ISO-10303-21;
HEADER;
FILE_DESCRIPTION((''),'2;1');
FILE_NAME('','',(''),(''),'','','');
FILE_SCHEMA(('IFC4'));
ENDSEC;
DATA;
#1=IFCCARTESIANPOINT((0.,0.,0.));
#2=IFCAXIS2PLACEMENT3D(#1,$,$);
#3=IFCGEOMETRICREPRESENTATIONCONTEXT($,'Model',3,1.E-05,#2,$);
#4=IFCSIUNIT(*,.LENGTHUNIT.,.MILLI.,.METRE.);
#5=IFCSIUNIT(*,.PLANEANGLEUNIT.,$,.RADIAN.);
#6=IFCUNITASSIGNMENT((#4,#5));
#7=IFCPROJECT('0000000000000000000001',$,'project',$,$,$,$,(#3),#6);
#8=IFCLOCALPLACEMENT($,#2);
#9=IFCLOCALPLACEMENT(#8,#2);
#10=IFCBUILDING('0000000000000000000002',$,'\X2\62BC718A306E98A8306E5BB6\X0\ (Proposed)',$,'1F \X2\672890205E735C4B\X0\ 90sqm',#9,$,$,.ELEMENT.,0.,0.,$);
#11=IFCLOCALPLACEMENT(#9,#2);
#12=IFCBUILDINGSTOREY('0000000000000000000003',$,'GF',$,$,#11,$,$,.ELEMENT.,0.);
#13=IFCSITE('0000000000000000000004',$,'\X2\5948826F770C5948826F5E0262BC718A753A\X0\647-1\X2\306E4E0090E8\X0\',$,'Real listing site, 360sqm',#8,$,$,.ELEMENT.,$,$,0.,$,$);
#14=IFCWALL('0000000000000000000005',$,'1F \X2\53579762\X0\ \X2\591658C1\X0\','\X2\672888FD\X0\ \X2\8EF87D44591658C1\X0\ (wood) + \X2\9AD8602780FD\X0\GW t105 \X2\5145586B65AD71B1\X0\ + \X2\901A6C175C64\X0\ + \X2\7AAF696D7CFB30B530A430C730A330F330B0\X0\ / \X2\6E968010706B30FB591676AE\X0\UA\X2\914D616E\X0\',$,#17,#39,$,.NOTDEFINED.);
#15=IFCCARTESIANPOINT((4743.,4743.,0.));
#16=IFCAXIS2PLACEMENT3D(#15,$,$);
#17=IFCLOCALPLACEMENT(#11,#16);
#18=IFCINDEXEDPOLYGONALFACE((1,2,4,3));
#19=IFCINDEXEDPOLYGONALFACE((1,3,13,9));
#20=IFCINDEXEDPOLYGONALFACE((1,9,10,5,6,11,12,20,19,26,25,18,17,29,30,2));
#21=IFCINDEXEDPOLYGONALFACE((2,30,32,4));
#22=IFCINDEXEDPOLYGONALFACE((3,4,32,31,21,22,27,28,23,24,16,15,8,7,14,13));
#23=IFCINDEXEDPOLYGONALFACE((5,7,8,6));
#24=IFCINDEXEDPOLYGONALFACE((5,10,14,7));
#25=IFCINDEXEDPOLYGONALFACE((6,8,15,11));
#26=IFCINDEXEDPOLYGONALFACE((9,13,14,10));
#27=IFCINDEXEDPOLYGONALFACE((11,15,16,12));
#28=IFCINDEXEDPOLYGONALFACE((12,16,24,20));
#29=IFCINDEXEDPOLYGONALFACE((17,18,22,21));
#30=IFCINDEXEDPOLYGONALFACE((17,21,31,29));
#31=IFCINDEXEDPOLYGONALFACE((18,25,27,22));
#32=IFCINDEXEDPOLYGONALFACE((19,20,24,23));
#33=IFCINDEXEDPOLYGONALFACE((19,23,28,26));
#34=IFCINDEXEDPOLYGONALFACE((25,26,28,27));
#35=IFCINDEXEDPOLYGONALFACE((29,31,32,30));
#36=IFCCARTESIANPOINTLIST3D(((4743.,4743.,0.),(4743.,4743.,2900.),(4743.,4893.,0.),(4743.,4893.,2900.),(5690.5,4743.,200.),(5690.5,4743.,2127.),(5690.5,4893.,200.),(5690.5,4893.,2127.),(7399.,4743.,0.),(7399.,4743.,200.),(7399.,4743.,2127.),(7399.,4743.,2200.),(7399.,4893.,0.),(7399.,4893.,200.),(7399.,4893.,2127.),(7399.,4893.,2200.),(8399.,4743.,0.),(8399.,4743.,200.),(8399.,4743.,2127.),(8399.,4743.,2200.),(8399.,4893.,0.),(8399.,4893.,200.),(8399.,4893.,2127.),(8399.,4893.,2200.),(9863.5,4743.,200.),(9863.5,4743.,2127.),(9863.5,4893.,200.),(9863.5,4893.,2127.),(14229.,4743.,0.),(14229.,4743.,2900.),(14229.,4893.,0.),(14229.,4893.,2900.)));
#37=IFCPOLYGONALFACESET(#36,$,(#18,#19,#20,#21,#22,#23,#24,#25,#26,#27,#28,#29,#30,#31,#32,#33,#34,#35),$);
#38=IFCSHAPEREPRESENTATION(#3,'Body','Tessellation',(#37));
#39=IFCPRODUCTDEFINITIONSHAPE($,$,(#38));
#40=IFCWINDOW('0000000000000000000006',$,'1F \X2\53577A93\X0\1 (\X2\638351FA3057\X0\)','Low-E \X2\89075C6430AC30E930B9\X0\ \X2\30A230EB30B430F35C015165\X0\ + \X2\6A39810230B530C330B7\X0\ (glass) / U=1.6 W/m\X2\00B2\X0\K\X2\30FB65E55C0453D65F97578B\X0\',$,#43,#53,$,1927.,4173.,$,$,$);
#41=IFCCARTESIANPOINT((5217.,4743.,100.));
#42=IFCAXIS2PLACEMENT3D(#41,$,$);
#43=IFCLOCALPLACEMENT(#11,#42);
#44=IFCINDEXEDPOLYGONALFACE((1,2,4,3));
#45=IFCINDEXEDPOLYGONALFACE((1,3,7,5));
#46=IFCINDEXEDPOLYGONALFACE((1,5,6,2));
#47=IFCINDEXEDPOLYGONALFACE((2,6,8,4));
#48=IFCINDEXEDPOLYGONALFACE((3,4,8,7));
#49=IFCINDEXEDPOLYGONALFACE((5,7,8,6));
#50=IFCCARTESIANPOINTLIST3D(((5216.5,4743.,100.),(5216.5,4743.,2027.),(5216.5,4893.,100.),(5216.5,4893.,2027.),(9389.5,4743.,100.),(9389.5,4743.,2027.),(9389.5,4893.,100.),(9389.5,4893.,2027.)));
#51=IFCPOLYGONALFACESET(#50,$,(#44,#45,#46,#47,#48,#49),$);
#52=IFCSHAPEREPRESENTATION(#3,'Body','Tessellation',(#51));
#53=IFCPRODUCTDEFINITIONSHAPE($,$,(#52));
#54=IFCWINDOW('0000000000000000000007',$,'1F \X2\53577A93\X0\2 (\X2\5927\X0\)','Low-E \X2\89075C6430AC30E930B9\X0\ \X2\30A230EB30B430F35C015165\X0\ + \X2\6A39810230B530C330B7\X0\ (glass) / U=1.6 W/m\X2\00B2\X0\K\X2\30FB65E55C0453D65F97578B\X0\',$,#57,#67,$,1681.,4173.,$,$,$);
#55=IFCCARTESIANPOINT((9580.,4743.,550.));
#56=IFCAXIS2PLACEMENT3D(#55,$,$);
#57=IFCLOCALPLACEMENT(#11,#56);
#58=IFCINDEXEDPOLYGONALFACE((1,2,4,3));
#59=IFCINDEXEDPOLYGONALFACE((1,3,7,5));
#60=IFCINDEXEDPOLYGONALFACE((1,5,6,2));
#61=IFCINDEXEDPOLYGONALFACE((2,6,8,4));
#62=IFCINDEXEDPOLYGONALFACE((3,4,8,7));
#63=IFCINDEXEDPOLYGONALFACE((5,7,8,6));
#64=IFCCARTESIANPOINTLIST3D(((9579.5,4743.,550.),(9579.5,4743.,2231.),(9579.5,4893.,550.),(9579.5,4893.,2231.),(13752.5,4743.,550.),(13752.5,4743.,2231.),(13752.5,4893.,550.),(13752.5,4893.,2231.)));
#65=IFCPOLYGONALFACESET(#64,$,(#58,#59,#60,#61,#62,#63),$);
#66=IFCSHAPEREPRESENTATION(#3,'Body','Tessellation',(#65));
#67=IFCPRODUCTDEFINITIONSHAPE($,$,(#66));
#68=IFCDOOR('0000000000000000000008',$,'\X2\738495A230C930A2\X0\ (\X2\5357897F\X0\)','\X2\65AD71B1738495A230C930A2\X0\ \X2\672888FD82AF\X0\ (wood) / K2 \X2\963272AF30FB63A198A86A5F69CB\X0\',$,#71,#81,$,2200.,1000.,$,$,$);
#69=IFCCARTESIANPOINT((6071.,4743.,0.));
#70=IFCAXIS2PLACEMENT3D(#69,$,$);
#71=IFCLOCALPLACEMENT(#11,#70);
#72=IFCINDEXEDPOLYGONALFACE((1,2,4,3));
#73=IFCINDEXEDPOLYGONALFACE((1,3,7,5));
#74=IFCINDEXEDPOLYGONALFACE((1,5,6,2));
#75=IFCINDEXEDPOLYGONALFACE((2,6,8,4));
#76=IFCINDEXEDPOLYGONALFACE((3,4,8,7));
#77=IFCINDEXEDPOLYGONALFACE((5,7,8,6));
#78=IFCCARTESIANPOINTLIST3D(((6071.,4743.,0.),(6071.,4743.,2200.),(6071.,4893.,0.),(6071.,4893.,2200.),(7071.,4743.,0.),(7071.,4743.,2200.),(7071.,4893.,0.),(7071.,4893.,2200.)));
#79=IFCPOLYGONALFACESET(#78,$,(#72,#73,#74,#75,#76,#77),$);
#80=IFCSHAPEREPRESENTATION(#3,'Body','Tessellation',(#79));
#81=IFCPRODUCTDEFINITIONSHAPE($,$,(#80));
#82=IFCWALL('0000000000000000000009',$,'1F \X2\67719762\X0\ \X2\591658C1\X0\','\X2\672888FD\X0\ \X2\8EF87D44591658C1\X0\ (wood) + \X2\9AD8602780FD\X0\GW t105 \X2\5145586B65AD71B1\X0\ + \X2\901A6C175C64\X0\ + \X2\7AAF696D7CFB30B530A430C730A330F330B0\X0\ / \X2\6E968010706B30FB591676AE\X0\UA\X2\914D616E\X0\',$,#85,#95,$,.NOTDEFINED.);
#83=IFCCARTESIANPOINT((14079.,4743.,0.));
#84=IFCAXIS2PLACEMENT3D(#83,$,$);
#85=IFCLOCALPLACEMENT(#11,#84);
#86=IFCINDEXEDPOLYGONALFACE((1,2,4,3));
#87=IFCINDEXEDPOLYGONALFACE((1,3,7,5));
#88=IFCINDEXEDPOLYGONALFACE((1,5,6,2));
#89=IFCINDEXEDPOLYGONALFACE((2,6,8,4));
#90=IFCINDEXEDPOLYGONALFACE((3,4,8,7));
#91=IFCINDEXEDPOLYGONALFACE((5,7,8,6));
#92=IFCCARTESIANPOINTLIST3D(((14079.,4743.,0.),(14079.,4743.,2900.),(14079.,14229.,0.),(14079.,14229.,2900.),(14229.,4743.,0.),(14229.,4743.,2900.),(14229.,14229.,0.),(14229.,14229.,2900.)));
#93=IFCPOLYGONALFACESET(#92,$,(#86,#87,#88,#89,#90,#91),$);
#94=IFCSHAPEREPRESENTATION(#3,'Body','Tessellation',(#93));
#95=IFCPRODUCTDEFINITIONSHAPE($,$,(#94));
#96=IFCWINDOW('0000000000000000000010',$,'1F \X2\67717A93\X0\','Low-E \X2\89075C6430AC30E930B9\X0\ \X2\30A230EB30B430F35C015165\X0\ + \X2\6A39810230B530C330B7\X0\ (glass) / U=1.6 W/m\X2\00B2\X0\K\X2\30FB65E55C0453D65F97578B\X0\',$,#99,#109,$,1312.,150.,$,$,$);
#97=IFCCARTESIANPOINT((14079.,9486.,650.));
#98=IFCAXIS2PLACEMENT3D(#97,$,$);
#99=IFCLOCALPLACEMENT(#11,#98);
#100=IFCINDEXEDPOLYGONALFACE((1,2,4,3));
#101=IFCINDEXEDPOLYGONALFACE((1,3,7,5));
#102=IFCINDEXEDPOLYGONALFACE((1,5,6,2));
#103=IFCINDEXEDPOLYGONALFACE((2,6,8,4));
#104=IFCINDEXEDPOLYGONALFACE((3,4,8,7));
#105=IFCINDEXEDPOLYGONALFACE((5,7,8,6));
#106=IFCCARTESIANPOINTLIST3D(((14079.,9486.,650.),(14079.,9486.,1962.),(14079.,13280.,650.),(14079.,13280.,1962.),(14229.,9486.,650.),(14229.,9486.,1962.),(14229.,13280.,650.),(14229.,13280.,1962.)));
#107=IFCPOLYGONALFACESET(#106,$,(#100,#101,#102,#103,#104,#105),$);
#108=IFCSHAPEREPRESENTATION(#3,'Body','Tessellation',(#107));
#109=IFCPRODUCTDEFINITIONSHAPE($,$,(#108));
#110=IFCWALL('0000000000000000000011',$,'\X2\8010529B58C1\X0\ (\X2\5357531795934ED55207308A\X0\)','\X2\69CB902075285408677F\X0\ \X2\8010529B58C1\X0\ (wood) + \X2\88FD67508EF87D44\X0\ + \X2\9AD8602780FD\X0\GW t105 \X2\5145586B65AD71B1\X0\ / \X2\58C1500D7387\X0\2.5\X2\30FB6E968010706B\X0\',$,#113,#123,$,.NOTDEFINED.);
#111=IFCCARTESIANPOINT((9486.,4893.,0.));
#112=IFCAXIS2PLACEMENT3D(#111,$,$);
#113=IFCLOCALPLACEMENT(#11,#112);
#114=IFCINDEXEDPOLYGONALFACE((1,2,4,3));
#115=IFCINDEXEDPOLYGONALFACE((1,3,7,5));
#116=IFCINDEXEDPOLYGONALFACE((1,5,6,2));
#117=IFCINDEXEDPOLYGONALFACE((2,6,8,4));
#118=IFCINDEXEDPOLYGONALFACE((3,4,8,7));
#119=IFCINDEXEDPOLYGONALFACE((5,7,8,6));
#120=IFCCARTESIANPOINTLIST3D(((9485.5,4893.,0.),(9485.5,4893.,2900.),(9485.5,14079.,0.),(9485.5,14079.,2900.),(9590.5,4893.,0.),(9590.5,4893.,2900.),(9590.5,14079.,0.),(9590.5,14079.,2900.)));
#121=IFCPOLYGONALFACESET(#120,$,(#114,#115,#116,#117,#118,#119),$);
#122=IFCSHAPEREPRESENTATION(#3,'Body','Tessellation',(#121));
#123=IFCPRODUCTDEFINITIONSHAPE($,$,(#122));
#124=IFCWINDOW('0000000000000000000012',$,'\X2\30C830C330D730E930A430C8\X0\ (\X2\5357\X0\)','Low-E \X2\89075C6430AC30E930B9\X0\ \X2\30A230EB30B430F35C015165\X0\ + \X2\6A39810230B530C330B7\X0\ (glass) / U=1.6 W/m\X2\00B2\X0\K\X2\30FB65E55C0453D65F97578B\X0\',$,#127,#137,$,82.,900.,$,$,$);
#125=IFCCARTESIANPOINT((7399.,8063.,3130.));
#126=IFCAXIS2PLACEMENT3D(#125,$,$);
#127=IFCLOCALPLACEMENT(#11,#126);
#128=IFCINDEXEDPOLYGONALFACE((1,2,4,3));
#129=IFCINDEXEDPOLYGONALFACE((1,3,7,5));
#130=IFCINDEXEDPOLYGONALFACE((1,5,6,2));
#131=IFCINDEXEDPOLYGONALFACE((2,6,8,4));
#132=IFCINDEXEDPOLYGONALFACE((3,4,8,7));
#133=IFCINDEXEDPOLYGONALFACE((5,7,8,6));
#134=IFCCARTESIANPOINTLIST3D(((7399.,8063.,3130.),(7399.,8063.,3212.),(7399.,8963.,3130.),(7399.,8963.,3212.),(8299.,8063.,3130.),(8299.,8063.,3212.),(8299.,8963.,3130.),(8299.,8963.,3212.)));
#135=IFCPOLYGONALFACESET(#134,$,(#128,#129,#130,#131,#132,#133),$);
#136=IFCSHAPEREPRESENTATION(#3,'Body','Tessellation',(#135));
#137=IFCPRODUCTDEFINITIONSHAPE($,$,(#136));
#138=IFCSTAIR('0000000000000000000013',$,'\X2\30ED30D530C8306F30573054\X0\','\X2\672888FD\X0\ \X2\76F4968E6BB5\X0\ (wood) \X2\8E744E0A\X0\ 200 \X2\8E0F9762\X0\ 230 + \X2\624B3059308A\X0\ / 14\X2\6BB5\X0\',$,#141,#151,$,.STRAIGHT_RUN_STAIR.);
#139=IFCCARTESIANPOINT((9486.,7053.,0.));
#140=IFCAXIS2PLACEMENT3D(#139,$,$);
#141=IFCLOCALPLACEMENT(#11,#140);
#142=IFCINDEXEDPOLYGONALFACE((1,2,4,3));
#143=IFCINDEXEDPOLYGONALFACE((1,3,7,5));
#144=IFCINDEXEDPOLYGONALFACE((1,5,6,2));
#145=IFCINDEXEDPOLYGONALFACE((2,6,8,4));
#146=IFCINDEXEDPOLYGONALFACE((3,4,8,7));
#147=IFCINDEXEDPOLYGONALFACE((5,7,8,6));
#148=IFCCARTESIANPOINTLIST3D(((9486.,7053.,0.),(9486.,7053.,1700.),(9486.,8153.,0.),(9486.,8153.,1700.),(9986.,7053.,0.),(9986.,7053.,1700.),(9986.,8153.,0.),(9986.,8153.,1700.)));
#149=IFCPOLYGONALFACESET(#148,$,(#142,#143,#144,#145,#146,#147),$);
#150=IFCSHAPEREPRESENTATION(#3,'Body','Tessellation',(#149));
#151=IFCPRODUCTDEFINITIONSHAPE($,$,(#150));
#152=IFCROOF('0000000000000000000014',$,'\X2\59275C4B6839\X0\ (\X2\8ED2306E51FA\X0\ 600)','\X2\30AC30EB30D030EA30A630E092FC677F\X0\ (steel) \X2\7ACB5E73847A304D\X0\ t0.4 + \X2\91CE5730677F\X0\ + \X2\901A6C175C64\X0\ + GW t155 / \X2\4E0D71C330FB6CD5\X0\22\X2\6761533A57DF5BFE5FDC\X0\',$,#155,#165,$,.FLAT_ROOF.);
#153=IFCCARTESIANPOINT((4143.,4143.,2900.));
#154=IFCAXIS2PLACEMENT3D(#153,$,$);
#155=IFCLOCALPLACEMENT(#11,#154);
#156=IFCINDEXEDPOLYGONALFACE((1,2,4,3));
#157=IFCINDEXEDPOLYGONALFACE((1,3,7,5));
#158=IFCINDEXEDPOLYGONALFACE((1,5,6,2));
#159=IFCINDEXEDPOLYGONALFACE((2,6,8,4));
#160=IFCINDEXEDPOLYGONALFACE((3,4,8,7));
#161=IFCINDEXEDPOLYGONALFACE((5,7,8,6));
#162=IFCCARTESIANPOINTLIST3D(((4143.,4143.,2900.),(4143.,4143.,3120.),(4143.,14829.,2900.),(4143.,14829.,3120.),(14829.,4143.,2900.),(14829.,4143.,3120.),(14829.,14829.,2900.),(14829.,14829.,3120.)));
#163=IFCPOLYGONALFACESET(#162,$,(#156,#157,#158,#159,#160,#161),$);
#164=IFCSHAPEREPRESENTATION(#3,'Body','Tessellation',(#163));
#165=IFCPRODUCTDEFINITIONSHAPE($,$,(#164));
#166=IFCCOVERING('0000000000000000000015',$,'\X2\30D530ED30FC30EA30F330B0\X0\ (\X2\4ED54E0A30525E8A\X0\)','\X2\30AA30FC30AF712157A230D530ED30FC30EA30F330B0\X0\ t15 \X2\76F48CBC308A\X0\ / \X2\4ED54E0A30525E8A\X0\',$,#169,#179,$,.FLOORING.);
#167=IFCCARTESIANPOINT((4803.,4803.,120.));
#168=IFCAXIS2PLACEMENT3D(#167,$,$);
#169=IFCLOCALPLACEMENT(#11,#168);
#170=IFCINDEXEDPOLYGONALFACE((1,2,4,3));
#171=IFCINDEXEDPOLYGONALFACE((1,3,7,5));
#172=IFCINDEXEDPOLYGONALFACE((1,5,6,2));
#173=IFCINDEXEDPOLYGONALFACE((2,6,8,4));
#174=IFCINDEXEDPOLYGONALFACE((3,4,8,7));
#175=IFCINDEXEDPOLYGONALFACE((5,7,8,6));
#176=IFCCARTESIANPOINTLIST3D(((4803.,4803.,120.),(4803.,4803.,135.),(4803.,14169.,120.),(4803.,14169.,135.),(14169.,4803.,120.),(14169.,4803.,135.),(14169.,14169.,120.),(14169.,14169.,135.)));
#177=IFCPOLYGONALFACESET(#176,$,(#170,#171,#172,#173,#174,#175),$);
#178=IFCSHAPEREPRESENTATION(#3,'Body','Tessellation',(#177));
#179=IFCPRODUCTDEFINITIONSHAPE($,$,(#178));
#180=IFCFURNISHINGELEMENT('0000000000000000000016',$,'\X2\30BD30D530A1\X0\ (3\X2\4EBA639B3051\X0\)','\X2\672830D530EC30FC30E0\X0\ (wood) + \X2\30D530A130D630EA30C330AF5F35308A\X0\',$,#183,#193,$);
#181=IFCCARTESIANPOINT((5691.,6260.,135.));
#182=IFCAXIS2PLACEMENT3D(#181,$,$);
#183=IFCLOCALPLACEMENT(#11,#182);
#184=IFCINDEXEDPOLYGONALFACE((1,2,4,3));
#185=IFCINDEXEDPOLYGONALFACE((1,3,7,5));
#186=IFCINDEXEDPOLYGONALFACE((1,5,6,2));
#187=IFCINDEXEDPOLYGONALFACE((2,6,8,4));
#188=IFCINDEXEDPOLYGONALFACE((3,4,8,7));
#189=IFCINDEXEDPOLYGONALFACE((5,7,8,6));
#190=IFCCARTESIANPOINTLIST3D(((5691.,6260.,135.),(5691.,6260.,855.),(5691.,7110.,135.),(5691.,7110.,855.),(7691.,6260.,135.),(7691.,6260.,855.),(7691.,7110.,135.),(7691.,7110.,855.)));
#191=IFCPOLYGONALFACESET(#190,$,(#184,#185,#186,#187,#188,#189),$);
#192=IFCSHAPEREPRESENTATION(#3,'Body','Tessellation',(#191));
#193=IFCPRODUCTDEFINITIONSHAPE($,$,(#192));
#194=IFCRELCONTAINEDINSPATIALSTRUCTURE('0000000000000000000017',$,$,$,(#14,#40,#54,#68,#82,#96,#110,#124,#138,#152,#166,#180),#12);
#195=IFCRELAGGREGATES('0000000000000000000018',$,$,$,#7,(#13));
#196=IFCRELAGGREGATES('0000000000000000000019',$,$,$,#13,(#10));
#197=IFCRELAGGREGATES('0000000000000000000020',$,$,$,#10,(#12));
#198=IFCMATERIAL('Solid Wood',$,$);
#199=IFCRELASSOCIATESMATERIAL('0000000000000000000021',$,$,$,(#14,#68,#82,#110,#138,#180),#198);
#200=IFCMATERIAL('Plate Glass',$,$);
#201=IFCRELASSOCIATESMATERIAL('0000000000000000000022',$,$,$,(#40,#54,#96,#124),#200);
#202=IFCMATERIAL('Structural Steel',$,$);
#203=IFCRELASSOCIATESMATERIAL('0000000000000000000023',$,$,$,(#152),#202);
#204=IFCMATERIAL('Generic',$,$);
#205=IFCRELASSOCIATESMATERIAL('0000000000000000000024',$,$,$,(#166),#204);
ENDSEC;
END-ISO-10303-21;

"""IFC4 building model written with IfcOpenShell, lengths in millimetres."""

from ifc_helpers import new_model, si_unit, frame, frame_2d, origin, place, context, project, spatial, rectangle, extrude, material, element, fill, save


model = new_model("IFC4")

# Units and contexts
model_context = context("Model", 3, precision=1e-05, world=origin())
ifc_project = project(units=[si_unit("LENGTHUNIT", "METRE", prefix="MILLI"), si_unit("PLANEANGLEUNIT", "RADIAN")], contexts=[model_context])

# Site, building, storey
site_placement = place(None, origin())
site = spatial("IfcSite", under=ifc_project, at=site_placement, Name="奈良県奈良市押熊町647-1の一部", ObjectType="Real listing site, 360sqm", CompositionType="ELEMENT", RefElevation=0.0)
building_placement = place(site_placement, origin())
building = spatial("IfcBuilding", under=site, at=building_placement, Name="押熊の風の家 (Proposed)", ObjectType="1F 木造平屋 90sqm", CompositionType="ELEMENT", ElevationOfRefHeight=0.0, ElevationOfTerrain=0.0)
storey_placement = place(building_placement, origin())
storey = spatial("IfcBuildingStorey", under=building, at=storey_placement, Name="GF", CompositionType="ELEMENT", Elevation=0.0)

# Shared definitions
ifc_material_1 = material(Name="Solid Wood")

# Wall, openings, windows, door
wall_1_placement = place(storey_placement, frame((4743.0, 4743.0, 0.0)))
wall_1 = element("IfcWall", 1, at=wall_1_placement, inside=storey, material=ifc_material_1, Name="1F 南面 外壁", Description="木製 軸組外壁 (wood) + 高性能GW t105 充填断熱 + 通気層 + 窯業系サイディング / 準耐火・外皮UA配慮", PredefinedType="NOTDEFINED", context=model_context, shape_type="SweptSolid", body=[
    extrude(rectangle(XDim=9486.0, YDim=150.0, at=frame_2d((4743.0, 75.0))), frame((4743.0, 4743.0, 0.0)), (0.0, 0.0, 1.0), 2900.0),
])
opening_1_placement = place(storey_placement, frame((5217.0, 4743.0, 100.0)))
opening_1 = element("IfcOpeningElement", 2, at=opening_1_placement, cuts=wall_1, PredefinedType="NOTDEFINED", context=model_context, shape_type="SweptSolid", body=[
    extrude(rectangle(XDim=4173.0, YDim=150.0, at=frame_2d((2086.0, 75.0))), frame((5217.0, 4743.0, 100.0)), (0.0, 0.0, 1.0), 1927.0),
])
opening_2_placement = place(storey_placement, frame((9580.0, 4743.0, 550.0)))
opening_2 = element("IfcOpeningElement", 3, at=opening_2_placement, cuts=wall_1, PredefinedType="NOTDEFINED", context=model_context, shape_type="SweptSolid", body=[
    extrude(rectangle(XDim=4173.0, YDim=150.0, at=frame_2d((2086.0, 75.0))), frame((9580.0, 4743.0, 550.0)), (0.0, 0.0, 1.0), 1681.0),
])
opening_3_placement = place(storey_placement, frame((6071.0, 4743.0, 0.0)))
opening_3 = element("IfcOpeningElement", 4, at=opening_3_placement, cuts=wall_1, PredefinedType="NOTDEFINED", context=model_context, shape_type="SweptSolid", body=[
    extrude(rectangle(XDim=1000.0, YDim=150.0, at=frame_2d((500.0, 75.0))), frame((6071.0, 4743.0, 0.0)), (0.0, 0.0, 1.0), 2200.0),
])
ifc_material_2 = material(Name="Plate Glass")
window_1_placement = place(storey_placement, frame((5217.0, 4743.0, 100.0)))
window_1 = element("IfcWindow", 5, at=window_1_placement, inside=storey, material=ifc_material_2, Name="1F 南窓1 (掃出し)", Description="Low-E 複層ガラス アルゴン封入 + 樹脂サッシ (glass) / U=1.6 W/m²K・日射取得型", OverallHeight=1927.0, OverallWidth=4173.0, context=model_context, shape_type="SweptSolid", body=[
    extrude(rectangle(XDim=4173.0, YDim=150.0, at=frame_2d((2086.0, 75.0))), frame((5217.0, 4743.0, 100.0)), (0.0, 0.0, 1.0), 1927.0),
])
fill(opening_1, window_1)
window_2_placement = place(storey_placement, frame((9580.0, 4743.0, 550.0)))
window_2 = element("IfcWindow", 6, at=window_2_placement, inside=storey, material=ifc_material_2, Name="1F 南窓2 (大)", Description="Low-E 複層ガラス アルゴン封入 + 樹脂サッシ (glass) / U=1.6 W/m²K・日射取得型", OverallHeight=1681.0, OverallWidth=4173.0, context=model_context, shape_type="SweptSolid", body=[
    extrude(rectangle(XDim=4173.0, YDim=150.0, at=frame_2d((2086.0, 75.0))), frame((9580.0, 4743.0, 550.0)), (0.0, 0.0, 1.0), 1681.0),
])
fill(opening_2, window_2)
door_placement = place(storey_placement, frame((6071.0, 4743.0, 0.0)))
door = element("IfcDoor", 7, at=door_placement, inside=storey, material=ifc_material_1, Name="玄関ドア (南西)", Description="断熱玄関ドア 木製芯 (wood) / K2 防犯・採風機構", OverallHeight=2200.0, OverallWidth=1000.0, context=model_context, shape_type="SweptSolid", body=[
    extrude(rectangle(XDim=1000.0, YDim=150.0, at=frame_2d((500.0, 75.0))), frame((6071.0, 4743.0, 0.0)), (0.0, 0.0, 1.0), 2200.0),
])
fill(opening_3, door)

# Wall, opening, window
wall_2_placement = place(storey_placement, frame((14079.0, 4743.0, 0.0)))
wall_2 = element("IfcWall", 8, at=wall_2_placement, inside=storey, material=ifc_material_1, Name="1F 東面 外壁", Description="木製 軸組外壁 (wood) + 高性能GW t105 充填断熱 + 通気層 + 窯業系サイディング / 準耐火・外皮UA配慮", PredefinedType="NOTDEFINED", context=model_context, shape_type="SweptSolid", body=[
    extrude(rectangle(XDim=150.0, YDim=9486.0, at=frame_2d((75.0, 4743.0))), frame((14079.0, 4743.0, 0.0)), (0.0, 0.0, 1.0), 2900.0),
])
opening_4_placement = place(storey_placement, frame((14079.0, 9486.0, 650.0)))
opening_4 = element("IfcOpeningElement", 9, at=opening_4_placement, cuts=wall_2, PredefinedType="NOTDEFINED", context=model_context, shape_type="SweptSolid", body=[
    extrude(rectangle(XDim=150.0, YDim=3794.0, at=frame_2d((75.0, 1897.0))), frame((14079.0, 9486.0, 650.0)), (0.0, 0.0, 1.0), 1312.0),
])
window_3_placement = place(storey_placement, frame((14079.0, 9486.0, 650.0)))
window_3 = element("IfcWindow", 10, at=window_3_placement, inside=storey, material=ifc_material_2, Name="1F 東窓", Description="Low-E 複層ガラス アルゴン封入 + 樹脂サッシ (glass) / U=1.6 W/m²K・日射取得型", OverallHeight=1312.0, OverallWidth=150.0, context=model_context, shape_type="SweptSolid", body=[
    extrude(rectangle(XDim=150.0, YDim=3794.0, at=frame_2d((75.0, 1897.0))), frame((14079.0, 9486.0, 650.0)), (0.0, 0.0, 1.0), 1312.0),
])
fill(opening_4, window_3)

# Wall
wall_3_placement = place(storey_placement, frame((9486.0, 4893.0, 0.0)))
element("IfcWall", 11, at=wall_3_placement, inside=storey, material=ifc_material_1, Name="耐力壁 (南北間仕切り)", Description="構造用合板 耐力壁 (wood) + 製材軸組 + 高性能GW t105 充填断熱 / 壁倍率2.5・準耐火", PredefinedType="NOTDEFINED", context=model_context, shape_type="SweptSolid", body=[
    extrude(rectangle(XDim=105.0, YDim=9186.0, at=frame_2d((52.0, 4593.0))), frame((9486.0, 4893.0, 0.0)), (0.0, 0.0, 1.0), 2900.0),
])

# Window
window_4_placement = place(storey_placement, frame((7399.0, 8063.0, 3130.0)))
element("IfcWindow", 12, at=window_4_placement, inside=storey, material=ifc_material_2, Name="トップライト (南)", Description="Low-E 複層ガラス アルゴン封入 + 樹脂サッシ (glass) / U=1.6 W/m²K・日射取得型", OverallHeight=82.0, OverallWidth=900.0, context=model_context, shape_type="SweptSolid", body=[
    extrude(rectangle(XDim=900.0, YDim=900.0, at=frame_2d((450.0, 450.0))), frame((7399.0, 8063.0, 3130.0)), (0.0, 0.0, 1.0), 82.0),
])

# Stair
stair_placement = place(storey_placement, frame((9486.0, 7053.0, 0.0)))
element("IfcStair", 13, at=stair_placement, inside=storey, material=ifc_material_1, Name="ロフトはしご", Description="木製 直階段 (wood) 蹴上 200 踏面 230 + 手すり / 14段", PredefinedType="STRAIGHT_RUN_STAIR", context=model_context, shape_type="SweptSolid", body=[
    extrude(rectangle(XDim=500.0, YDim=1100.0, at=frame_2d((250.0, 550.0))), frame((9486.0, 7053.0, 0.0)), (0.0, 0.0, 1.0), 1700.0),
])

# Roof
ifc_material_3 = material(Name="Structural Steel")
roof_placement = place(storey_placement, frame((4143.0, 4143.0, 2900.0)))
element("IfcRoof", 14, at=roof_placement, inside=storey, material=ifc_material_3, Name="大屋根 (軒の出 600)", Description="ガルバリウム鋼板 (steel) 立平葺き t0.4 + 野地板 + 通気層 + GW t155 / 不燃・法22条区域対応", PredefinedType="FLAT_ROOF", context=model_context, shape_type="SweptSolid", body=[
    extrude(rectangle(XDim=10686.0, YDim=10686.0, at=frame_2d((5343.0, 5343.0))), frame((4143.0, 4143.0, 2900.0)), (0.0, 0.0, 1.0), 220.0),
])

# Covering
ifc_material_4 = material(Name="Generic")
covering_placement = place(storey_placement, frame((4803.0, 4803.0, 120.0)))
element("IfcCovering", 15, at=covering_placement, inside=storey, material=ifc_material_4, Name="フローリング (仕上げ床)", Description="オーク無垢フローリング t15 直貼り / 仕上げ床", PredefinedType="FLOORING", context=model_context, shape_type="SweptSolid", body=[
    extrude(rectangle(XDim=9366.0, YDim=9366.0, at=frame_2d((4683.0, 4683.0))), frame((4803.0, 4803.0, 120.0)), (0.0, 0.0, 1.0), 15.0),
])

# Furnishing element
furnishing_1_placement = place(storey_placement, frame((5691.0, 6260.0, 135.0)))
element("IfcFurnishingElement", 16, at=furnishing_1_placement, inside=storey, material=ifc_material_1, Name="ソファ (3人掛け)", Description="木フレーム (wood) + ファブリック張り", context=model_context, shape_type="SweptSolid", body=[
    extrude(rectangle(XDim=2000.0, YDim=850.0, at=frame_2d((1000.0, 425.0))), frame((5691.0, 6260.0, 135.0)), (0.0, 0.0, 1.0), 720.0),
])

save(model, "model.ifc")
